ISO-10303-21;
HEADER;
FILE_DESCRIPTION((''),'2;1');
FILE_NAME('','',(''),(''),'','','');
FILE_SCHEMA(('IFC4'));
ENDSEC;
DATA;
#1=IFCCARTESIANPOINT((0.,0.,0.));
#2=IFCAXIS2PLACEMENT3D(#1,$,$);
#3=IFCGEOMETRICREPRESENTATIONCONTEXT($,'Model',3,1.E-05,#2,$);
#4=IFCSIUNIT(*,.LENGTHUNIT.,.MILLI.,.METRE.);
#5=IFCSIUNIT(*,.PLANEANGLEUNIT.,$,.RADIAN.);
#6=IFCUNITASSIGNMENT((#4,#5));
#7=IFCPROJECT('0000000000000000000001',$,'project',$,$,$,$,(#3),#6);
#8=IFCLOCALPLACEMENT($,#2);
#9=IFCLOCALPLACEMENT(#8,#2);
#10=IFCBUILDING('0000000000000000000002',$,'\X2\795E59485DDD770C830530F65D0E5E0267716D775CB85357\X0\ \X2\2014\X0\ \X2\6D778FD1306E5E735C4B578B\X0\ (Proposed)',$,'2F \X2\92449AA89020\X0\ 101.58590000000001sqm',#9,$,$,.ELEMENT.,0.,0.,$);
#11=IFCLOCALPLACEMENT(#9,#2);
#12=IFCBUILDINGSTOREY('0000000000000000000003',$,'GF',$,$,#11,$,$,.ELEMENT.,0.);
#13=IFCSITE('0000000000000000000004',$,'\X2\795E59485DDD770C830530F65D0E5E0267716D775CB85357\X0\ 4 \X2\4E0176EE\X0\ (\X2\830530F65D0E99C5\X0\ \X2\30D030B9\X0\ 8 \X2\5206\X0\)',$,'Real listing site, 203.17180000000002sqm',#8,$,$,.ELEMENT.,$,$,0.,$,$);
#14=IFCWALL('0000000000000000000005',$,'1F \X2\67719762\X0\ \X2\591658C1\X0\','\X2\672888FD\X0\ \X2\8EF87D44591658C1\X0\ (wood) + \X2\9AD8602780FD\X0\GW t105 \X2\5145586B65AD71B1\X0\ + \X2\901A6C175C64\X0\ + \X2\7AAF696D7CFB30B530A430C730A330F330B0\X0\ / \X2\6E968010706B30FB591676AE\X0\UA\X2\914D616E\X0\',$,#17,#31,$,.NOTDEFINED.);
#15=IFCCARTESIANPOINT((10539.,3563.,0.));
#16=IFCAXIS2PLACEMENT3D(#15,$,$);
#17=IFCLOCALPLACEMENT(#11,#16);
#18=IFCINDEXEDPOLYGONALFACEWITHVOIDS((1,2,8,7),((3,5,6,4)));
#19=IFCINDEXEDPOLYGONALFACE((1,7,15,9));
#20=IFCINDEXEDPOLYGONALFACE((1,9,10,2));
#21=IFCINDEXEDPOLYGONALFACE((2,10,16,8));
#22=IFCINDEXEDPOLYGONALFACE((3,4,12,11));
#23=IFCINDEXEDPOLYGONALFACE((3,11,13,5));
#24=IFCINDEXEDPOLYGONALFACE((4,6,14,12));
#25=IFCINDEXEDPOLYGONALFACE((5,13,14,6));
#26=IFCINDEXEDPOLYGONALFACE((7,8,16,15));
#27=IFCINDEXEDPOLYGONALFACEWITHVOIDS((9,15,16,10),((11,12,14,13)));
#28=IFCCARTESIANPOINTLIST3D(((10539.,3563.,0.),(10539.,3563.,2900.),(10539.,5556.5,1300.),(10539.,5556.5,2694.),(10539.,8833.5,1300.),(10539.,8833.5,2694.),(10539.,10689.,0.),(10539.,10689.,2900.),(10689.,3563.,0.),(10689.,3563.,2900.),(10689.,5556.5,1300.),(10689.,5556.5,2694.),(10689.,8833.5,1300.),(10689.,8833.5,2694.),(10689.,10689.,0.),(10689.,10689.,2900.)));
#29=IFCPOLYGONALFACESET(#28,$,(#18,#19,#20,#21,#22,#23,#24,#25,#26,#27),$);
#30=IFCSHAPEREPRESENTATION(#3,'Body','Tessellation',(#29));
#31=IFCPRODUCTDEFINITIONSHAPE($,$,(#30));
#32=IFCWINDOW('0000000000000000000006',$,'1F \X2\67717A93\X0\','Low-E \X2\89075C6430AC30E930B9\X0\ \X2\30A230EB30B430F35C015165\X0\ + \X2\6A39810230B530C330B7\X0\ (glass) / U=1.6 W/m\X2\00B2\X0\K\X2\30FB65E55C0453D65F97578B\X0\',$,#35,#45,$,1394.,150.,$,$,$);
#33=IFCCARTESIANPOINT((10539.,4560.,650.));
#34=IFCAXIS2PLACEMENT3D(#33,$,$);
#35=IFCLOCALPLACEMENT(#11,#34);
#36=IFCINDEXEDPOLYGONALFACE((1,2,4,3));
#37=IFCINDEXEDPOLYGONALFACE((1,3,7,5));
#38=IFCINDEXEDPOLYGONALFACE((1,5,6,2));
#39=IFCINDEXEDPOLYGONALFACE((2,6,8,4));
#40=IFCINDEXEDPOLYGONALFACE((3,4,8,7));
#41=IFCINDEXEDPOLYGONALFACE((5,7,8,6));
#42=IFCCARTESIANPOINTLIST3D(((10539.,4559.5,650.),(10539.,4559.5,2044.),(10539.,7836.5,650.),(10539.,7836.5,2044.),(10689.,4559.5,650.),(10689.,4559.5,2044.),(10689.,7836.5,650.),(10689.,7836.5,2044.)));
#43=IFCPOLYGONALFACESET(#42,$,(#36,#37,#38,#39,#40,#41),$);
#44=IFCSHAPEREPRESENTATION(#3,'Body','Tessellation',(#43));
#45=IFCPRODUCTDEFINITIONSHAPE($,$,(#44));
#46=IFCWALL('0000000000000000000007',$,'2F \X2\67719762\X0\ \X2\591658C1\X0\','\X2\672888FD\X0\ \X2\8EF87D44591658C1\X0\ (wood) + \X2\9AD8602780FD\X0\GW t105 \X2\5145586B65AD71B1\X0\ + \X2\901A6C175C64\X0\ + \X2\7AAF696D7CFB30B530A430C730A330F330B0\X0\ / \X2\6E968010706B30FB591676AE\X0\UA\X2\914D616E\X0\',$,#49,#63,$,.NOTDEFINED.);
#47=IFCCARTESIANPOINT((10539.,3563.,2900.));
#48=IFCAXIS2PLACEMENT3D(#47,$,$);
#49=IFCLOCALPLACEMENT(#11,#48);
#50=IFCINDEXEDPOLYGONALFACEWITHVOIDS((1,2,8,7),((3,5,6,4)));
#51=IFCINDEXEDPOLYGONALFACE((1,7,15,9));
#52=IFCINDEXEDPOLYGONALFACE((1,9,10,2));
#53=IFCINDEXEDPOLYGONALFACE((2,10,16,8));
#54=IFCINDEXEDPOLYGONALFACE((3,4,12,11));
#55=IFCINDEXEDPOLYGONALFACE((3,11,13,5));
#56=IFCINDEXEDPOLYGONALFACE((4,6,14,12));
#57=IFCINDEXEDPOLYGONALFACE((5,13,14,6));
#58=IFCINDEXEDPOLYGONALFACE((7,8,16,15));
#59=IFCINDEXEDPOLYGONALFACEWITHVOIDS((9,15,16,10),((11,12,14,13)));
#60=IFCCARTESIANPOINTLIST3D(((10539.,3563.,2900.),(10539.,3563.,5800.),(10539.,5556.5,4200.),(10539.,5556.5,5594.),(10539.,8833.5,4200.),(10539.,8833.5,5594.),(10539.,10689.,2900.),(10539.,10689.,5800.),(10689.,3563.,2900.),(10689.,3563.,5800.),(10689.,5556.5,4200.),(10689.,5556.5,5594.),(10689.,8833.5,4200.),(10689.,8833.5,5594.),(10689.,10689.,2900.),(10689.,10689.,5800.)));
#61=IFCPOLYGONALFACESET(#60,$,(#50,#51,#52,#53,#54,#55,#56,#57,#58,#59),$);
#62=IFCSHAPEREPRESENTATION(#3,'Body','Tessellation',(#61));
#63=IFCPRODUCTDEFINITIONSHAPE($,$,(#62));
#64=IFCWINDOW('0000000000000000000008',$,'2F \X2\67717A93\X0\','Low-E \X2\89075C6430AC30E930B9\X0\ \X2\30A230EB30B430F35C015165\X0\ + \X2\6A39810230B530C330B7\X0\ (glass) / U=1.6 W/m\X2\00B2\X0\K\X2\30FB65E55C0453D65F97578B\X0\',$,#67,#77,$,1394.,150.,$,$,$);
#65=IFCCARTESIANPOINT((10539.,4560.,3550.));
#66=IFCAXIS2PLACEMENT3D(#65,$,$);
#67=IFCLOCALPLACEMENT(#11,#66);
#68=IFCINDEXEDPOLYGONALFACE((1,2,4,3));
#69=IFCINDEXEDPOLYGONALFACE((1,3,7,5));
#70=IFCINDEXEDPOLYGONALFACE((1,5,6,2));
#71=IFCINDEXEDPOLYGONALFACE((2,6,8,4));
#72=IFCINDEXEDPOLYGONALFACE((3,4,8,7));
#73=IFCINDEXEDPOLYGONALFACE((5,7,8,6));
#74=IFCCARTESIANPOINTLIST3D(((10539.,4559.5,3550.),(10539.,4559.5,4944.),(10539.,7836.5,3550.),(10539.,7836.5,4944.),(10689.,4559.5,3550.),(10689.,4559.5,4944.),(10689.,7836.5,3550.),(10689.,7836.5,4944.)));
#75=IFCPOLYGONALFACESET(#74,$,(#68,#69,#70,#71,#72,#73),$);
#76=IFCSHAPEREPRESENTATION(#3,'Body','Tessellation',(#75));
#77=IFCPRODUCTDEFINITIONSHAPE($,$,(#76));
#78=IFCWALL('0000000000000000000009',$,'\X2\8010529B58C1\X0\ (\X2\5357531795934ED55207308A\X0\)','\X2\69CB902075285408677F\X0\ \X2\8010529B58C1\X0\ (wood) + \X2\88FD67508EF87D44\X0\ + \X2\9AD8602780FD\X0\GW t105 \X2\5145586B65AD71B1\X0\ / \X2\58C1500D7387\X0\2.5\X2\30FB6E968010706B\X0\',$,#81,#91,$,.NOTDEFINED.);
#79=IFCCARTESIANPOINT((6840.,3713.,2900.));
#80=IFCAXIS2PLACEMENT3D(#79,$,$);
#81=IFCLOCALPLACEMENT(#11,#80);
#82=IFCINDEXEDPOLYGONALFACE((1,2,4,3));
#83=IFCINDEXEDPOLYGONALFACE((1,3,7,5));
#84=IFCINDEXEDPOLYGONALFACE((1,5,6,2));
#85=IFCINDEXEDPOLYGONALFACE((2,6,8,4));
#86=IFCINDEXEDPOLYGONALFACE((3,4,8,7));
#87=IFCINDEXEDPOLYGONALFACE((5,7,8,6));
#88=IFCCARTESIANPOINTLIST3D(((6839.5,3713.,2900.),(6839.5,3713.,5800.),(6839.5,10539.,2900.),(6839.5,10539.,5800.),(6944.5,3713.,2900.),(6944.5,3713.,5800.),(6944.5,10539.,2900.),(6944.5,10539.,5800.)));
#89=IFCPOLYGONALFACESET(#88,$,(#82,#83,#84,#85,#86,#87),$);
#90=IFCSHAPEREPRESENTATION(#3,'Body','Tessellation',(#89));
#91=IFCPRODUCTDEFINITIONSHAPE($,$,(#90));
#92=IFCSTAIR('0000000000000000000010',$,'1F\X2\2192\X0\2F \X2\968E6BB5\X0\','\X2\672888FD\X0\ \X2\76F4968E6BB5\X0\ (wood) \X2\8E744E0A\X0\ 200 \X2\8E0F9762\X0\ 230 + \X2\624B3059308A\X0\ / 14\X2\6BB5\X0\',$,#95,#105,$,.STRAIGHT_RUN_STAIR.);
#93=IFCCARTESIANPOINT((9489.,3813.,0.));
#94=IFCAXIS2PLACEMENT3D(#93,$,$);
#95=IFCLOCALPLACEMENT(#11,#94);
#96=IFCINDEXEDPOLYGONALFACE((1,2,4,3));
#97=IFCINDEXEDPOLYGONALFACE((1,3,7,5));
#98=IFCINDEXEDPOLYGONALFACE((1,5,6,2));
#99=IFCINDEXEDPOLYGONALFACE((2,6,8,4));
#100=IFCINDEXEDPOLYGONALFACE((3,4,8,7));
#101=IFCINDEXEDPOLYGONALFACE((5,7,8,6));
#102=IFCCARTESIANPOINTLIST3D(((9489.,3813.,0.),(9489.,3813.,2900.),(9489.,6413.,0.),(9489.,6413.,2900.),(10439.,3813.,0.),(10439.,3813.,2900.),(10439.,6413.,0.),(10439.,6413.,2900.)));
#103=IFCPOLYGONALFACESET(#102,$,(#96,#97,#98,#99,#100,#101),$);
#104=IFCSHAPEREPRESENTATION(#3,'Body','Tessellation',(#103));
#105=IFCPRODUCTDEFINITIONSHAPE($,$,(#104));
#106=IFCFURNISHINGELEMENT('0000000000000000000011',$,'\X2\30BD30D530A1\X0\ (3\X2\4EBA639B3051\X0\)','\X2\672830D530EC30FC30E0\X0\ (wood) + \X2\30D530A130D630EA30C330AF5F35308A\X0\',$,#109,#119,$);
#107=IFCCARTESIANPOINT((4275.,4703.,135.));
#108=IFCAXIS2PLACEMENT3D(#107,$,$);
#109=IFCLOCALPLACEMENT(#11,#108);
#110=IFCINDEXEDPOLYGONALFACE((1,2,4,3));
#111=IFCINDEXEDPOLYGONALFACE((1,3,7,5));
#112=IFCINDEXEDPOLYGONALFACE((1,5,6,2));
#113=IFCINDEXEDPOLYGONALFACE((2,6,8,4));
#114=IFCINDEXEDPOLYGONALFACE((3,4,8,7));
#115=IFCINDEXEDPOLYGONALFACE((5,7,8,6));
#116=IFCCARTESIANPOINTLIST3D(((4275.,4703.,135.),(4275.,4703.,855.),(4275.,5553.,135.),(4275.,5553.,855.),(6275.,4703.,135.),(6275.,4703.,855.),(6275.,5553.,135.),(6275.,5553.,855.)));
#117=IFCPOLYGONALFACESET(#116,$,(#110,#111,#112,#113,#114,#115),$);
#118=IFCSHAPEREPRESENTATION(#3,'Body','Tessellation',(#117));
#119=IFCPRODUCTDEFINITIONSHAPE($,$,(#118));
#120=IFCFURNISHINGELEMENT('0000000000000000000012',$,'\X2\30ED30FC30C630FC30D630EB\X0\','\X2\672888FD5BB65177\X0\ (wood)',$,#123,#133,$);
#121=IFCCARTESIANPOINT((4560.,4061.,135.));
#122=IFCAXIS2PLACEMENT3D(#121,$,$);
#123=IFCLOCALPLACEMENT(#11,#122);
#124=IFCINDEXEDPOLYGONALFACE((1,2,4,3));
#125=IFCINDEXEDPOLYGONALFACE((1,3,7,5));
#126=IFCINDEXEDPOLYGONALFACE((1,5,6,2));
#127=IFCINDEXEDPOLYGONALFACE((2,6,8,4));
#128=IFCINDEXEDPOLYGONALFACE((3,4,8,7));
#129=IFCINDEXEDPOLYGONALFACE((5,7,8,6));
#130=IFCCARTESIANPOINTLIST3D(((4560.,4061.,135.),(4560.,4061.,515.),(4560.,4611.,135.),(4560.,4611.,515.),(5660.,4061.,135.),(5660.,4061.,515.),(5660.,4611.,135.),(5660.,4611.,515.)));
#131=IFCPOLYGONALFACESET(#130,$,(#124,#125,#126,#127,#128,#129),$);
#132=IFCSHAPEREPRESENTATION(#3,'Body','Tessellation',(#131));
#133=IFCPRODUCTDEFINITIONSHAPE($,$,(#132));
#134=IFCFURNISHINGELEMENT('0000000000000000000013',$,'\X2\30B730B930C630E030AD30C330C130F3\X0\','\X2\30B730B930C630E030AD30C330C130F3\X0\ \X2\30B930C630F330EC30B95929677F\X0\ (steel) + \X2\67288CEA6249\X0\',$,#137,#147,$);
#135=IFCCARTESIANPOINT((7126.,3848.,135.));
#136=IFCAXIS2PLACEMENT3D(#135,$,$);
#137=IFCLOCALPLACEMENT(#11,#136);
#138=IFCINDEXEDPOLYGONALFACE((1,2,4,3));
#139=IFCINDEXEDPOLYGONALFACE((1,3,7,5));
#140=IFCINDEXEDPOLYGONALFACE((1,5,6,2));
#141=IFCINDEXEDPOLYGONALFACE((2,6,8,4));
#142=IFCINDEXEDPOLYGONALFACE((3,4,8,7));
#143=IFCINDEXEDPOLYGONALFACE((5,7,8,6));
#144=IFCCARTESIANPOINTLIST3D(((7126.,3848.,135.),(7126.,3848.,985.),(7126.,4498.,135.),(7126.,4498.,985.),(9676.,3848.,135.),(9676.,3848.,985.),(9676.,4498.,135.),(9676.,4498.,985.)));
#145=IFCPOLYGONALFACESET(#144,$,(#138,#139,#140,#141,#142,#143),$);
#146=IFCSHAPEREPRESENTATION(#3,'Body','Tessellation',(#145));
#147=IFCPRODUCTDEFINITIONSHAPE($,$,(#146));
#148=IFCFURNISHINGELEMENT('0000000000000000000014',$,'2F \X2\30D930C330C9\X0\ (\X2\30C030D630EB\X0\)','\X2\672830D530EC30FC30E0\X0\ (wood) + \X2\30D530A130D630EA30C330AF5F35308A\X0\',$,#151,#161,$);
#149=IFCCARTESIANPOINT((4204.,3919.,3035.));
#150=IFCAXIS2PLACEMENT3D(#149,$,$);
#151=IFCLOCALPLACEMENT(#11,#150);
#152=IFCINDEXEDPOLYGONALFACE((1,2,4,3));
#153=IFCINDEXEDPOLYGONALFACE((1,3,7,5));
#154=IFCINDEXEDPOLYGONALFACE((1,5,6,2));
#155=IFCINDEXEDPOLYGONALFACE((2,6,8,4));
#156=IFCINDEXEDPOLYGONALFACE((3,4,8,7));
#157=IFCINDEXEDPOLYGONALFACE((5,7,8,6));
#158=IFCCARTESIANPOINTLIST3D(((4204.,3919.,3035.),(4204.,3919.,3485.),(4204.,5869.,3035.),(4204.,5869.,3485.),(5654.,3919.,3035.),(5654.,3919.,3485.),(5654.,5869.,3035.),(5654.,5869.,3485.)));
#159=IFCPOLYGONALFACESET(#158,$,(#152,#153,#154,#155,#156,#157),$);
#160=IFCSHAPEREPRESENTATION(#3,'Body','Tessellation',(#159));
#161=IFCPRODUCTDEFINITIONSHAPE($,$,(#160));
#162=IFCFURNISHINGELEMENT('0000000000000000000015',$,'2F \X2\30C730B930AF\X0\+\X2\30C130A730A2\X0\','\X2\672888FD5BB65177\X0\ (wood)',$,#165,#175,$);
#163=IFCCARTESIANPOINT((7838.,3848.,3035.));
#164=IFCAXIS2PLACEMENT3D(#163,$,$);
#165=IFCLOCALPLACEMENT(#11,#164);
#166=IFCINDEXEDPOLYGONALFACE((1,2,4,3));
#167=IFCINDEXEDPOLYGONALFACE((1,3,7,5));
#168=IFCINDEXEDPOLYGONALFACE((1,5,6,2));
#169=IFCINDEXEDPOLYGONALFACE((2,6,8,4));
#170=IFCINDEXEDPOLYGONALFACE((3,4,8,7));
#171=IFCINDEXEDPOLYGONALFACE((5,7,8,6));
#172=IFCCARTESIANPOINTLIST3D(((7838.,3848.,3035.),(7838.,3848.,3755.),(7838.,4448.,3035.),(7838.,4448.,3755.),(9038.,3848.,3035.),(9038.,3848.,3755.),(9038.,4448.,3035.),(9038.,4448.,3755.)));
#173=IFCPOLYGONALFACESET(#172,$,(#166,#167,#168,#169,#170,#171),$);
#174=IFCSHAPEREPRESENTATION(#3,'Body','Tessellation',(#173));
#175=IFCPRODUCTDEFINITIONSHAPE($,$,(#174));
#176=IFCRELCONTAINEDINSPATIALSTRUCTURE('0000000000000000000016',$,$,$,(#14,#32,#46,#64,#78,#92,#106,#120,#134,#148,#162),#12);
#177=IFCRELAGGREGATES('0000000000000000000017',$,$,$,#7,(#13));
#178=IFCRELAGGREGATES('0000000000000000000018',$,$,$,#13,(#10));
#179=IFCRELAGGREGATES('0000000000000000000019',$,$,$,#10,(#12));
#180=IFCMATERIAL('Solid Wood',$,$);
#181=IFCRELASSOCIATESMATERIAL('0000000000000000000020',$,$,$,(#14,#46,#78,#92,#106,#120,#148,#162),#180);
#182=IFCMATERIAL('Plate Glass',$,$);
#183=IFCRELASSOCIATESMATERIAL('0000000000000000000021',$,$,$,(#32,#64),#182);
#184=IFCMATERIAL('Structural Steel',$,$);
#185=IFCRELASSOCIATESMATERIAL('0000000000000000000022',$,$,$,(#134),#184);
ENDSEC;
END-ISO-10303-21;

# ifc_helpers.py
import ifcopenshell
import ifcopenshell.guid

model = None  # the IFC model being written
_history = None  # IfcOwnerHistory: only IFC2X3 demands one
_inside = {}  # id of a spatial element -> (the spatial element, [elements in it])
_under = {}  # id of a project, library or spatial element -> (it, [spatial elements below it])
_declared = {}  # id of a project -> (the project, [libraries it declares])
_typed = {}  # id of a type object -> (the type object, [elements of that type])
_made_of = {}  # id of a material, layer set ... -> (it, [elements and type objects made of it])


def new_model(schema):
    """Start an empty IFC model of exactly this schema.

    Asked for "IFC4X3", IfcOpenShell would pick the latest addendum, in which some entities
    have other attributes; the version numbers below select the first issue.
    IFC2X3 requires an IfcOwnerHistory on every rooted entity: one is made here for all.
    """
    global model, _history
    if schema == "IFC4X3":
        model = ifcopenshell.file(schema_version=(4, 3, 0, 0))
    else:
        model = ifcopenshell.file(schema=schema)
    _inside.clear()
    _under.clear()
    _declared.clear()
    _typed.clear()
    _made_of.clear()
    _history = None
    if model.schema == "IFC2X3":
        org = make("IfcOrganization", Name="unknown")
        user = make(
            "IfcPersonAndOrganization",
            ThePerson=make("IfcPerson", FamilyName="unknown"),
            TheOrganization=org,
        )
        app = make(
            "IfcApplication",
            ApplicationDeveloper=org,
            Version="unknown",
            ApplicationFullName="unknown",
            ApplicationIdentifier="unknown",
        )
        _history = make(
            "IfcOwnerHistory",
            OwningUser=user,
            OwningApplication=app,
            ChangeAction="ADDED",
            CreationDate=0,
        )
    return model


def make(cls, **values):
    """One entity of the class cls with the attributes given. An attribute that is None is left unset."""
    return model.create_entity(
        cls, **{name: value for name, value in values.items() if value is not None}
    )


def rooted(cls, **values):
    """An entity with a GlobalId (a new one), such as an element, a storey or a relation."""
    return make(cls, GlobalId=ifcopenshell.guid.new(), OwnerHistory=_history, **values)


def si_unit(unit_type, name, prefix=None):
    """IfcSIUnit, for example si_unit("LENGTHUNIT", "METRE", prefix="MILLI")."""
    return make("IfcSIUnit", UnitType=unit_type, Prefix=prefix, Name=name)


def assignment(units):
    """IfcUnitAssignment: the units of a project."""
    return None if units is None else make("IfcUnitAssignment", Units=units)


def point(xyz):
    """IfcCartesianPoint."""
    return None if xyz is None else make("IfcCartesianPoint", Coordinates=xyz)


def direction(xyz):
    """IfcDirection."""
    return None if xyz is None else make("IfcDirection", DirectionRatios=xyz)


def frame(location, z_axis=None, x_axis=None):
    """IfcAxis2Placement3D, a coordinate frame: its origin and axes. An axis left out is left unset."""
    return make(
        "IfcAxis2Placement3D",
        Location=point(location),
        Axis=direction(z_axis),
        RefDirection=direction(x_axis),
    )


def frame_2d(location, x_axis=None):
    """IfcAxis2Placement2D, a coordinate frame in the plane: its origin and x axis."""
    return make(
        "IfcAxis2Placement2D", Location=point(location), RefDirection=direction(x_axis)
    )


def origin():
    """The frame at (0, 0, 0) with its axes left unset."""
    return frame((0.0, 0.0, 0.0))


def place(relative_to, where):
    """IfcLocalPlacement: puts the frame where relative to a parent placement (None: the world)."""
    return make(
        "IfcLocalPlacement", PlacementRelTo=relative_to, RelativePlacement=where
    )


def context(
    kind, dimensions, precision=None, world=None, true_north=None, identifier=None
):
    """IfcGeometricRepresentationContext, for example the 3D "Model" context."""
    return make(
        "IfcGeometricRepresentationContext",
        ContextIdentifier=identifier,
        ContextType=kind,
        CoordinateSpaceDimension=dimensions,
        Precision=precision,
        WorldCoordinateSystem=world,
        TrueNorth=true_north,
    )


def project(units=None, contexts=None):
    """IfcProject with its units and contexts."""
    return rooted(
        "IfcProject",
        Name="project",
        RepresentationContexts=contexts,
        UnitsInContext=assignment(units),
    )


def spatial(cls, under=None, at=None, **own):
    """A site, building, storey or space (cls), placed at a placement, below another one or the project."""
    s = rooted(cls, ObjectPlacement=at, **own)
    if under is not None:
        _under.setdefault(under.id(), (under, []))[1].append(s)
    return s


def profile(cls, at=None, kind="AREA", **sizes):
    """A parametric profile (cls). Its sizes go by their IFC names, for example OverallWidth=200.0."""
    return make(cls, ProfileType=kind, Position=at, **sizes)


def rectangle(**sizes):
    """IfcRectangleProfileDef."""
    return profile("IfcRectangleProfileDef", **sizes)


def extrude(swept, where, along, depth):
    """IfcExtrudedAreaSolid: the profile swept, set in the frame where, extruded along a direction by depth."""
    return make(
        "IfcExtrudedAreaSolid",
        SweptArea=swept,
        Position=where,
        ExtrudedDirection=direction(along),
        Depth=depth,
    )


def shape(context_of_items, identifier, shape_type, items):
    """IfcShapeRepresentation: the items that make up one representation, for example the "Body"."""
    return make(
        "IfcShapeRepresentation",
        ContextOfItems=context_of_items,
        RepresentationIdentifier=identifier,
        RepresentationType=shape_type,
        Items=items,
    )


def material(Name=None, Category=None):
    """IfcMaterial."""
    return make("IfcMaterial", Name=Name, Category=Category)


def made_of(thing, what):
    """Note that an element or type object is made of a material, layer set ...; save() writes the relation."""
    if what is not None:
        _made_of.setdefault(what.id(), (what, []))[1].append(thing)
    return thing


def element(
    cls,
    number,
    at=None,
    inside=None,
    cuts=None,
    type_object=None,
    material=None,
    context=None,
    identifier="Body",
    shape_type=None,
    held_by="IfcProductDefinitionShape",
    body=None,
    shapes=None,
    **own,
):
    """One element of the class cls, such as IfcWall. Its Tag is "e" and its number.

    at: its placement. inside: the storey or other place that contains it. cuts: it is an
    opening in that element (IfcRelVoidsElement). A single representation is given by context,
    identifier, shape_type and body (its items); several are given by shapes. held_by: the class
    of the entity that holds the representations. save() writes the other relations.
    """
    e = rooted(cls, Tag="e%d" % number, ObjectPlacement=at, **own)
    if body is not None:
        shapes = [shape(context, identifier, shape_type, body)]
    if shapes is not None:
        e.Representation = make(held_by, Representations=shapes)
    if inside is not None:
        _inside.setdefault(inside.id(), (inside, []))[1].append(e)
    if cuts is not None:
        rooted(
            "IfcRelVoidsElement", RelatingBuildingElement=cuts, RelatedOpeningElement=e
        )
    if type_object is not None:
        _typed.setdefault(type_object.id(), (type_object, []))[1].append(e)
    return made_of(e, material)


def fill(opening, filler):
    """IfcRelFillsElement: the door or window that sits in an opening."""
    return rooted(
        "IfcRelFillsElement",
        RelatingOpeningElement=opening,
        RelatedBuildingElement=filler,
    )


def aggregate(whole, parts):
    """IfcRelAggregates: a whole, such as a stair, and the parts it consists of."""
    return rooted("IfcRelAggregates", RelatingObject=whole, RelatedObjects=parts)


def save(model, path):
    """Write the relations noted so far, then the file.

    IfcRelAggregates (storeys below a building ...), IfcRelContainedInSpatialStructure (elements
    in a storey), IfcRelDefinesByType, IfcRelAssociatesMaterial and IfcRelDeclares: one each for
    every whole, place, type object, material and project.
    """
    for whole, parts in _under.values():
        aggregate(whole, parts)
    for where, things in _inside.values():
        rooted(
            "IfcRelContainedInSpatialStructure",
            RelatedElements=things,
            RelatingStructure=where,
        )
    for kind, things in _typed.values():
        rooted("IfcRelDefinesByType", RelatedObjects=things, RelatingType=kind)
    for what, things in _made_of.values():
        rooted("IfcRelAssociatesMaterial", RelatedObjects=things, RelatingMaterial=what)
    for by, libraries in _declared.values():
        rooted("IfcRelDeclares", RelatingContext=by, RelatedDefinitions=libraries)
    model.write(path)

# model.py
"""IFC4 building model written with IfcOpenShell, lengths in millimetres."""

from ifc_helpers import new_model, si_unit, frame, frame_2d, origin, place, context, project, spatial, rectangle, extrude, material, element, fill, save


model = new_model("IFC4")

# Units and contexts
model_context = context("Model", 3, precision=1e-05, world=origin())
ifc_project = project(units=[si_unit("LENGTHUNIT", "METRE", prefix="MILLI"), si_unit("PLANEANGLEUNIT", "RADIAN")], contexts=[model_context])

# Site, building, storey
site_placement = place(None, origin())
site = spatial("IfcSite", under=ifc_project, at=site_placement, Name="神奈川県茅ヶ崎市東海岸南 4 丁目 (茅ヶ崎駅 バス 8 分)", ObjectType="Real listing site, 203.17180000000002sqm", CompositionType="ELEMENT", RefElevation=0.0)
building_placement = place(site_placement, origin())
building = spatial("IfcBuilding", under=site, at=building_placement, Name="神奈川県茅ヶ崎市東海岸南 — 海近の平屋型 (Proposed)", ObjectType="2F 鉄骨造 101.58590000000001sqm", CompositionType="ELEMENT", ElevationOfRefHeight=0.0, ElevationOfTerrain=0.0)
storey_placement = place(building_placement, origin())
storey = spatial("IfcBuildingStorey", under=building, at=storey_placement, Name="GF", CompositionType="ELEMENT", Elevation=0.0)

# Wall, opening, window
ifc_material_1 = material(Name="Solid Wood")
wall_1_placement = place(storey_placement, frame((10539.0, 3563.0, 0.0)))
wall_1 = element("IfcWall", 1, at=wall_1_placement, inside=storey, material=ifc_material_1, Name="1F 東面 外壁", Description="木製 軸組外壁 (wood) + 高性能GW t105 充填断熱 + 通気層 + 窯業系サイディング / 準耐火・外皮UA配慮", PredefinedType="NOTDEFINED", context=model_context, shape_type="SweptSolid", body=[
    extrude(rectangle(XDim=150.0, YDim=7126.0, at=frame_2d((75.0, 3563.0))), frame((10539.0, 3563.0, 0.0)), (0.0, 0.0, 1.0), 2900.0),
])
opening_1_placement = place(storey_placement, frame((10539.0, 4560.0, 650.0)))
opening_1 = element("IfcOpeningElement", 2, at=opening_1_placement, cuts=wall_1, PredefinedType="NOTDEFINED", context=model_context, shape_type="SweptSolid", body=[
    extrude(rectangle(XDim=150.0, YDim=3277.0, at=frame_2d((75.0, 1638.0))), frame((10539.0, 4560.0, 650.0)), (0.0, 0.0, 1.0), 1394.0),
])
ifc_material_2 = material(Name="Plate Glass")
window_1_placement = place(storey_placement, frame((10539.0, 4560.0, 650.0)))
window_1 = element("IfcWindow", 3, at=window_1_placement, inside=storey, material=ifc_material_2, Name="1F 東窓", Description="Low-E 複層ガラス アルゴン封入 + 樹脂サッシ (glass) / U=1.6 W/m²K・日射取得型", OverallHeight=1394.0, OverallWidth=150.0, context=model_context, shape_type="SweptSolid", body=[
    extrude(rectangle(XDim=150.0, YDim=3277.0, at=frame_2d((75.0, 1638.0))), frame((10539.0, 4560.0, 650.0)), (0.0, 0.0, 1.0), 1394.0),
])
fill(opening_1, window_1)

# Wall, opening, window
wall_2_placement = place(storey_placement, frame((10539.0, 3563.0, 2900.0)))
wall_2 = element("IfcWall", 4, at=wall_2_placement, inside=storey, material=ifc_material_1, Name="2F 東面 外壁", Description="木製 軸組外壁 (wood) + 高性能GW t105 充填断熱 + 通気層 + 窯業系サイディング / 準耐火・外皮UA配慮", PredefinedType="NOTDEFINED", context=model_context, shape_type="SweptSolid", body=[
    extrude(rectangle(XDim=150.0, YDim=7126.0, at=frame_2d((75.0, 3563.0))), frame((10539.0, 3563.0, 2900.0)), (0.0, 0.0, 1.0), 2900.0),
])
opening_2_placement = place(storey_placement, frame((10539.0, 4560.0, 3550.0)))
opening_2 = element("IfcOpeningElement", 5, at=opening_2_placement, cuts=wall_2, PredefinedType="NOTDEFINED", context=model_context, shape_type="SweptSolid", body=[
    extrude(rectangle(XDim=150.0, YDim=3277.0, at=frame_2d((75.0, 1638.0))), frame((10539.0, 4560.0, 3550.0)), (0.0, 0.0, 1.0), 1394.0),
])
window_2_placement = place(storey_placement, frame((10539.0, 4560.0, 3550.0)))
window_2 = element("IfcWindow", 6, at=window_2_placement, inside=storey, material=ifc_material_2, Name="2F 東窓", Description="Low-E 複層ガラス アルゴン封入 + 樹脂サッシ (glass) / U=1.6 W/m²K・日射取得型", OverallHeight=1394.0, OverallWidth=150.0, context=model_context, shape_type="SweptSolid", body=[
    extrude(rectangle(XDim=150.0, YDim=3277.0, at=frame_2d((75.0, 1638.0))), frame((10539.0, 4560.0, 3550.0)), (0.0, 0.0, 1.0), 1394.0),
])
fill(opening_2, window_2)

# Wall
wall_3_placement = place(storey_placement, frame((6840.0, 3713.0, 2900.0)))
element("IfcWall", 7, at=wall_3_placement, inside=storey, material=ifc_material_1, Name="耐力壁 (南北間仕切り)", Description="構造用合板 耐力壁 (wood) + 製材軸組 + 高性能GW t105 充填断熱 / 壁倍率2.5・準耐火", PredefinedType="NOTDEFINED", context=model_context, shape_type="SweptSolid", body=[
    extrude(rectangle(XDim=105.0, YDim=6826.0, at=frame_2d((52.0, 3413.0))), frame((6840.0, 3713.0, 2900.0)), (0.0, 0.0, 1.0), 2900.0),
])

# Stair
stair_placement = place(storey_placement, frame((9489.0, 3813.0, 0.0)))
element("IfcStair", 8, at=stair_placement, inside=storey, material=ifc_material_1, Name="1F→2F 階段", Description="木製 直階段 (wood) 蹴上 200 踏面 230 + 手すり / 14段", PredefinedType="STRAIGHT_RUN_STAIR", context=model_context, shape_type="SweptSolid", body=[
    extrude(rectangle(XDim=950.0, YDim=2600.0, at=frame_2d((475.0, 1300.0))), frame((9489.0, 3813.0, 0.0)), (0.0, 0.0, 1.0), 2900.0),
])

# Furnishing elements
furnishing_1_placement = place(storey_placement, frame((4275.0, 4703.0, 135.0)))
element("IfcFurnishingElement", 9, at=furnishing_1_placement, inside=storey, material=ifc_material_1, Name="ソファ (3人掛け)", Description="木フレーム (wood) + ファブリック張り", context=model_context, shape_type="SweptSolid", body=[
    extrude(rectangle(XDim=2000.0, YDim=850.0, at=frame_2d((1000.0, 425.0))), frame((4275.0, 4703.0, 135.0)), (0.0, 0.0, 1.0), 720.0),
])
furnishing_2_placement = place(storey_placement, frame((4560.0, 4061.0, 135.0)))
element("IfcFurnishingElement", 10, at=furnishing_2_placement, inside=storey, material=ifc_material_1, Name="ローテーブル", Description="木製家具 (wood)", context=model_context, shape_type="SweptSolid", body=[
    extrude(rectangle(XDim=1100.0, YDim=550.0, at=frame_2d((550.0, 275.0))), frame((4560.0, 4061.0, 135.0)), (0.0, 0.0, 1.0), 380.0),
])
ifc_material_3 = material(Name="Structural Steel")
furnishing_3_placement = place(storey_placement, frame((7126.0, 3848.0, 135.0)))
element("IfcFurnishingElement", 11, at=furnishing_3_placement, inside=storey, material=ifc_material_3, Name="システムキッチン", Description="システムキッチン ステンレス天板 (steel) + 木質扉", context=model_context, shape_type="SweptSolid", body=[
    extrude(rectangle(XDim=2550.0, YDim=650.0, at=frame_2d((1275.0, 325.0))), frame((7126.0, 3848.0, 135.0)), (0.0, 0.0, 1.0), 850.0),
])
furnishing_4_placement = place(storey_placement, frame((4204.0, 3919.0, 3035.0)))
element("IfcFurnishingElement", 12, at=furnishing_4_placement, inside=storey, material=ifc_material_1, Name="2F ベッド (ダブル)", Description="木フレーム (wood) + ファブリック張り", context=model_context, shape_type="SweptSolid", body=[
    extrude(rectangle(XDim=1450.0, YDim=1950.0, at=frame_2d((725.0, 975.0))), frame((4204.0, 3919.0, 3035.0)), (0.0, 0.0, 1.0), 450.0),
])
furnishing_5_placement = place(storey_placement, frame((7838.0, 3848.0, 3035.0)))
element("IfcFurnishingElement", 13, at=furnishing_5_placement, inside=storey, material=ifc_material_1, Name="2F デスク+チェア", Description="木製家具 (wood)", context=model_context, shape_type="SweptSolid", body=[
    extrude(rectangle(XDim=1200.0, YDim=600.0, at=frame_2d((600.0, 300.0))), frame((7838.0, 3848.0, 3035.0)), (0.0, 0.0, 1.0), 720.0),
])

save(model, "model.ifc")
